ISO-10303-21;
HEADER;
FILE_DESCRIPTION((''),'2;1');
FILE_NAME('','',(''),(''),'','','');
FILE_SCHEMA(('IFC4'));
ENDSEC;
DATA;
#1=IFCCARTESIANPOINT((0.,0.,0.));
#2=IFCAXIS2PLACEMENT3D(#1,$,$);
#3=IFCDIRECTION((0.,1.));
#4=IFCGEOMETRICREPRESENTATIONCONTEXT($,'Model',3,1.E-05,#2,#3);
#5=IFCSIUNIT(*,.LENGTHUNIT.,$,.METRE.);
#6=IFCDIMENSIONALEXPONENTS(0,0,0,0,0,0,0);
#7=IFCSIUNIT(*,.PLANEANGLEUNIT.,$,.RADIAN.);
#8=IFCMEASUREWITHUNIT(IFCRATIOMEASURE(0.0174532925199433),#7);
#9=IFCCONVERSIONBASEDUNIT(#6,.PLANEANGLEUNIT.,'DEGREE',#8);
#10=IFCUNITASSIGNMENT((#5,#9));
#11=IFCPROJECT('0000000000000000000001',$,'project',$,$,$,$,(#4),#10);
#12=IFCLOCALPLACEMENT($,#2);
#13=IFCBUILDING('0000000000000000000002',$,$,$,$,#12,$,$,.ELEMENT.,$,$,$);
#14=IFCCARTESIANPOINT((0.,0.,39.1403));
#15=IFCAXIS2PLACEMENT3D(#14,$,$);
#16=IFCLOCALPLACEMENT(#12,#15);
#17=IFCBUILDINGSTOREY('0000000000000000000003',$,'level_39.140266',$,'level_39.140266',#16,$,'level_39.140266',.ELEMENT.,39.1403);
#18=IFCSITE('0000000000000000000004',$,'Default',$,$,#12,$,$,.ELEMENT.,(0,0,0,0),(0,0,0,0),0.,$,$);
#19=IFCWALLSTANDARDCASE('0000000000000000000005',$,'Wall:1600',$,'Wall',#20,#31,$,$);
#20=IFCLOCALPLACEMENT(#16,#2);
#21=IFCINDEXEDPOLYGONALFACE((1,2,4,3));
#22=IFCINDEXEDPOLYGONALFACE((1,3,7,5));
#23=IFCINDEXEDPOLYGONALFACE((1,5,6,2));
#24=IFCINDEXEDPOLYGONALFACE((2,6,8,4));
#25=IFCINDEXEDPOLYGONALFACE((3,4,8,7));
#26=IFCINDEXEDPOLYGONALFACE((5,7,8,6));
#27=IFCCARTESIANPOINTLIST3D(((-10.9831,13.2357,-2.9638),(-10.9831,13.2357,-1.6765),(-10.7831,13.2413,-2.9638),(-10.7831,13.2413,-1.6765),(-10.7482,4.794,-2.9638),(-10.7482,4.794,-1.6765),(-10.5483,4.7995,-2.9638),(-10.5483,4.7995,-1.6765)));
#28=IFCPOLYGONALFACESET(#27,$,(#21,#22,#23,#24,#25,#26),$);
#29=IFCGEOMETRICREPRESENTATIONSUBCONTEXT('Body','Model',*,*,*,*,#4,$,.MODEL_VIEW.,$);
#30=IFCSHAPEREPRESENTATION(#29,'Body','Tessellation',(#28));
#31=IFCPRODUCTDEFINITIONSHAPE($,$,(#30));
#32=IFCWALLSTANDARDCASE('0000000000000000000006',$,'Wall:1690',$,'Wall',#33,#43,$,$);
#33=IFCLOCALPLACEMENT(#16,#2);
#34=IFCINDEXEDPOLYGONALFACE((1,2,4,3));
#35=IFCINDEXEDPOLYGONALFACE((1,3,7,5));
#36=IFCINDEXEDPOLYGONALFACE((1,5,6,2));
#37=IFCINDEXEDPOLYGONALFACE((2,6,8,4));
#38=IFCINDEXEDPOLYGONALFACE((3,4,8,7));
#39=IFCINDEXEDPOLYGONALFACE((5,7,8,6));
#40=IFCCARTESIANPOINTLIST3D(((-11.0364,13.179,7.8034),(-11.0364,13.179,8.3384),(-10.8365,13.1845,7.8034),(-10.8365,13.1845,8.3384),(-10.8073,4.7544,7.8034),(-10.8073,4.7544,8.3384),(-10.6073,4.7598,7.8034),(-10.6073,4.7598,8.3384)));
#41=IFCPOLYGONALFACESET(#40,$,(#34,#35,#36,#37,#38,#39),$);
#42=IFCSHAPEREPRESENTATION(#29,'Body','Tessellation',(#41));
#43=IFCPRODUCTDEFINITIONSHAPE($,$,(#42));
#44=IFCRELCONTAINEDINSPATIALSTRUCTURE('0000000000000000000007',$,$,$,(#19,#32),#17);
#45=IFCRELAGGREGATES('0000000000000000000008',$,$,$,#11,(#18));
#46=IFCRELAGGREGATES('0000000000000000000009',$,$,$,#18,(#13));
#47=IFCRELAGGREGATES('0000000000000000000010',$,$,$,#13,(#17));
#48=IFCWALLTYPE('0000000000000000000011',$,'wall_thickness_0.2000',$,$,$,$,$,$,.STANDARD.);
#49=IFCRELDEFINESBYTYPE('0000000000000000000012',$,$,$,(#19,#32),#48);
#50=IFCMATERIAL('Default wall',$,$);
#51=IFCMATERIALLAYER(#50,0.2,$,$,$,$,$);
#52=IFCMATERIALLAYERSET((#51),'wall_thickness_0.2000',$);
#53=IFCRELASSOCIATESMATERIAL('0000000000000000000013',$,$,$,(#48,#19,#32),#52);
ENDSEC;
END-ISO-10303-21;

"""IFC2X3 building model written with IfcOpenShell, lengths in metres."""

from ifc_helpers import new_model, entity, si_unit, converted_unit, direction, frame, origin, place, context, subcontext, project, spatial, polyline, outline, extrude, material, layer, layer_set, layer_usage, type_object, element, save


model = new_model("IFC2X3")

# Units and contexts
model_context = context("Model", 3, precision=1e-05, world=origin(), true_north=direction((0.0, 1.0)))
body_context = subcontext(model_context, "Body", "Model", "MODEL_VIEW")
ifc_project = project(units=[si_unit("LENGTHUNIT", "METRE"), converted_unit("PLANEANGLEUNIT", "DEGREE", entity("IfcRatioMeasure", 0.0174532925199433), si_unit("PLANEANGLEUNIT", "RADIAN"), dimensions=[0, 0, 0, 0, 0, 0, 0])], contexts=[model_context])

# Site, building, storey
placement_1 = place(None, origin())
site = spatial("IfcSite", under=ifc_project, at=placement_1, Name="Default", CompositionType="ELEMENT", RefLatitude=(0, 0, 0, 0), RefLongitude=(0, 0, 0, 0), RefElevation=0.0)
building = spatial("IfcBuilding", under=site, at=placement_1, CompositionType="ELEMENT")
storey_placement = place(placement_1, frame((0.0, 0.0, 39.1403)))
storey = spatial("IfcBuildingStorey", under=building, at=storey_placement, Name="level_39.140266", ObjectType="level_39.140266", LongName="level_39.140266", CompositionType="ELEMENT", Elevation=39.1403)

# Shared definitions
ifc_material_1 = material(Name="Default wall")
ifc_layer = layer(ifc_material_1, 0.2)
ifc_layer_set = layer_set([ifc_layer], Name="wall_thickness_0.2000")
ifc_layer_usage = layer_usage(ifc_layer_set, "AXIS2", "POSITIVE", -0.1)
wall_type = type_object("IfcWallType", Name="wall_thickness_0.2000", PredefinedType="STANDARD", material=ifc_layer_set)

# Walls
placement_2 = place(placement_1, frame((0.0, 0.0, 36.1765)))
wall_1_placement = place(placement_2, frame((-10.8831, 13.2385, 0.0), z_axis=(0.0, 0.0, 1.0), x_axis=(0.02781, -0.999613, 0.0)))
element("IfcWallStandardCase", 1, at=wall_1_placement, inside=storey, type_object=wall_type, material=ifc_layer_usage, Name="Wall:1600", ObjectType="Wall", context=body_context, shape_type="SweptSolid", body=[
    extrude(outline(polyline([(8.445, -0.1), (8.445, 0.1), (0.0, 0.1), (0.0, -0.1), (8.445, -0.1)])), origin(), (0.0, 0.0, 1.0), 1.2873),
])
placement_3 = place(placement_1, frame((0.0, 0.0, 46.9437)))
wall_2_placement = place(placement_3, frame((-10.9364, 13.1818, 0.0), z_axis=(0.0, 0.0, 1.0), x_axis=(0.027188, -0.99963, 0.0)))
element("IfcWallStandardCase", 2, at=wall_2_placement, inside=storey, type_object=wall_type, material=ifc_layer_usage, Name="Wall:1690", ObjectType="Wall", context=body_context, shape_type="SweptSolid", body=[
    extrude(outline(polyline([(8.4278, -0.1), (8.4278, 0.1), (0.0, 0.1), (0.0, -0.1), (8.4278, -0.1)])), origin(), (0.0, 0.0, 1.0), 0.535),
])

save(model, "model.ifc")
